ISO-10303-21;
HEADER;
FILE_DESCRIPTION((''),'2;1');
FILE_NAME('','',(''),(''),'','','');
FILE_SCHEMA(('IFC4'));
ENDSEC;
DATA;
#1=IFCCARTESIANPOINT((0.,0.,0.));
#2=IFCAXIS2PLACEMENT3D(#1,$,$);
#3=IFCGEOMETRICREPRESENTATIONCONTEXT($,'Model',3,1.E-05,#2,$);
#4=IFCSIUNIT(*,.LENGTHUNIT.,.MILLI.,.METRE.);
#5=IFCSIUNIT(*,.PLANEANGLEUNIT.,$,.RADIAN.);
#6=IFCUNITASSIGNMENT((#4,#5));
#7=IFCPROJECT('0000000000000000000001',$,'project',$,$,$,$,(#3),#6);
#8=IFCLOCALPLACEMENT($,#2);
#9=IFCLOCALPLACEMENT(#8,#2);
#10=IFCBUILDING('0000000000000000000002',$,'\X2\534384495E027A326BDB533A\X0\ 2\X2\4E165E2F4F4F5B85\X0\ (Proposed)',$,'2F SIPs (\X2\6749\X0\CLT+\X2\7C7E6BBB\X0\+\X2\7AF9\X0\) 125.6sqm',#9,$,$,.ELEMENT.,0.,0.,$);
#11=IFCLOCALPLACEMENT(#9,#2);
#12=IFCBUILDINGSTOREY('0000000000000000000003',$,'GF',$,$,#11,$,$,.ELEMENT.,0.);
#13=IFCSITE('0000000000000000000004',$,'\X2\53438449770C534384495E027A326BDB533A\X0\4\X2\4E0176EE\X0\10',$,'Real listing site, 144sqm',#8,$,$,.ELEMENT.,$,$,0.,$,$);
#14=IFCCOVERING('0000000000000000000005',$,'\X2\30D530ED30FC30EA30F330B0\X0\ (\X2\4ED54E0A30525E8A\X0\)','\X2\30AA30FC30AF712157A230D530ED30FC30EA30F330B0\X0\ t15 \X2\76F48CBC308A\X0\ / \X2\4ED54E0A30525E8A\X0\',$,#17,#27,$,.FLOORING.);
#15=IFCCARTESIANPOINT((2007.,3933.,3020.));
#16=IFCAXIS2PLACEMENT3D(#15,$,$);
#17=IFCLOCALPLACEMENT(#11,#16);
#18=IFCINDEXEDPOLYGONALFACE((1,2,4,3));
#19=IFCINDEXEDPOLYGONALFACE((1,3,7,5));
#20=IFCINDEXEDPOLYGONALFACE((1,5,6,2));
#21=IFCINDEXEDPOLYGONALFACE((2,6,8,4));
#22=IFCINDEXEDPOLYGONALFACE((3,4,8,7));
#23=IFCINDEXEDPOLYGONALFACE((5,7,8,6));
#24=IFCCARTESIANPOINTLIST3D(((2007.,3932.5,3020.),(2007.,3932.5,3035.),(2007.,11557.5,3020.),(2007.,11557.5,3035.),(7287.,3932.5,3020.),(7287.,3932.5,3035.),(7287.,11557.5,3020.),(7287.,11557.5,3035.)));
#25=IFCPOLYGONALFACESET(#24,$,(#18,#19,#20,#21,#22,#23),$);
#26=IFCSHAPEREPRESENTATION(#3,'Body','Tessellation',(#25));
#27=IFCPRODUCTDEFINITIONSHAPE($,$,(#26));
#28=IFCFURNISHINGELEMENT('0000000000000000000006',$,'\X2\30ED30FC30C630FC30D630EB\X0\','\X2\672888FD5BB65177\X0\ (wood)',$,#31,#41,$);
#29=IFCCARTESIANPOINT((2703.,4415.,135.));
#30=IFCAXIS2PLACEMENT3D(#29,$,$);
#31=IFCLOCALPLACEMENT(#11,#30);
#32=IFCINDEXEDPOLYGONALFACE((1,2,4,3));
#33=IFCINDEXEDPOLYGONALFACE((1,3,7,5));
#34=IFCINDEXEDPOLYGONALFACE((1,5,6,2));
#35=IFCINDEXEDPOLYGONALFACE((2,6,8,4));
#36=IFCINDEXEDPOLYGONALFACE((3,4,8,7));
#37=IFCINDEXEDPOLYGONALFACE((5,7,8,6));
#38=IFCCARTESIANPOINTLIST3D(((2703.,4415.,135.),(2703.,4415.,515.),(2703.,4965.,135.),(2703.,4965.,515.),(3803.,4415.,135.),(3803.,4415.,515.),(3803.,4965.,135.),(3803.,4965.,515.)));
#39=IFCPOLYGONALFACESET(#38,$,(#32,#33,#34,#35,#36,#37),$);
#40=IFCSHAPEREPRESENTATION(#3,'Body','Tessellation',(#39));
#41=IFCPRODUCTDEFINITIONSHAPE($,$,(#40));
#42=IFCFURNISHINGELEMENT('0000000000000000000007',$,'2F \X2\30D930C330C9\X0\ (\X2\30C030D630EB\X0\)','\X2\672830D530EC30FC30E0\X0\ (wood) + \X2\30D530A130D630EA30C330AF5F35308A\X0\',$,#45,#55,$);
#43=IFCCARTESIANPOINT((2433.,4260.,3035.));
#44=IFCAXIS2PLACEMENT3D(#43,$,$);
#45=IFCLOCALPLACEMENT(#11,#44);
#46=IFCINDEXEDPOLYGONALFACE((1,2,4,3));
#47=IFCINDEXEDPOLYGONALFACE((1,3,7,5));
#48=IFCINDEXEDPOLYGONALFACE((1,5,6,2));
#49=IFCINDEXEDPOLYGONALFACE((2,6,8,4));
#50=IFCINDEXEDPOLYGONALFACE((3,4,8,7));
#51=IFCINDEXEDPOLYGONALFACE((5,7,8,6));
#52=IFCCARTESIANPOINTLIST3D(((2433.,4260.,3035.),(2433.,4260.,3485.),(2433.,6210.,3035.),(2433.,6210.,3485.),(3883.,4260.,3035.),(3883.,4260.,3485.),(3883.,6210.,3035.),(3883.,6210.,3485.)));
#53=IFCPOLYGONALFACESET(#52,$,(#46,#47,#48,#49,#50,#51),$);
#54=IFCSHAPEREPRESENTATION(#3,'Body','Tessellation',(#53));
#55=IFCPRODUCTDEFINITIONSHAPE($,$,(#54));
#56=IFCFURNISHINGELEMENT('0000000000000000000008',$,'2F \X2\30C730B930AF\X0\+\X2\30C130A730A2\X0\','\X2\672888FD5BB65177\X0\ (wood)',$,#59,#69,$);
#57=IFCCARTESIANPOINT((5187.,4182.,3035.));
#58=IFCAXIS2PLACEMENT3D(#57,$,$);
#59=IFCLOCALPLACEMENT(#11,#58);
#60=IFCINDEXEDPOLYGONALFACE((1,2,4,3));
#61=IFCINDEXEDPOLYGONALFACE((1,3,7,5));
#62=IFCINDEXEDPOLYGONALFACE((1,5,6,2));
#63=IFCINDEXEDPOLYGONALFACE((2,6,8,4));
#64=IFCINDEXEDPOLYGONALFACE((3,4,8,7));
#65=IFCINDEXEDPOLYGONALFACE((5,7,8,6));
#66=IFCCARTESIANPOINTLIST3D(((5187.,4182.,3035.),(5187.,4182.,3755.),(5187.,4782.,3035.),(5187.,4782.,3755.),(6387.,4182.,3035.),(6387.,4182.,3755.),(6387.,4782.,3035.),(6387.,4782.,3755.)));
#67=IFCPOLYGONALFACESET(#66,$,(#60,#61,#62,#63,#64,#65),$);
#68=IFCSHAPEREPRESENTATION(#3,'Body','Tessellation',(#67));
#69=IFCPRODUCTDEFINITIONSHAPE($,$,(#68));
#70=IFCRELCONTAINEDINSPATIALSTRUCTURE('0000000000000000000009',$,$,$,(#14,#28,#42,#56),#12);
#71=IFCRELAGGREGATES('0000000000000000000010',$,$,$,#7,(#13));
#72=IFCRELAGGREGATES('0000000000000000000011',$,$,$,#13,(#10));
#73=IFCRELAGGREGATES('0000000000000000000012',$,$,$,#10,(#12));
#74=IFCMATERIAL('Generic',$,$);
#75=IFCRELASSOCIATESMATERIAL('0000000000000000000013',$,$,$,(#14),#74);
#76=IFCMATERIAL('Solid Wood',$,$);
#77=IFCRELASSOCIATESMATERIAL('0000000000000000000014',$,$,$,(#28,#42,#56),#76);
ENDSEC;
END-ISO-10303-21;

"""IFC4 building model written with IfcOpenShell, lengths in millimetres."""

from ifc_helpers import new_model, si_unit, frame, frame_2d, origin, place, context, project, spatial, rectangle, extrude, material, element, save


model = new_model("IFC4")

# Units and contexts
model_context = context("Model", 3, precision=1e-05, world=origin())
ifc_project = project(units=[si_unit("LENGTHUNIT", "METRE", prefix="MILLI"), si_unit("PLANEANGLEUNIT", "RADIAN")], contexts=[model_context])

# Site, building, storey
site_placement = place(None, origin())
site = spatial("IfcSite", under=ifc_project, at=site_placement, Name="千葉県千葉市稲毛区4丁目10", ObjectType="Real listing site, 144sqm", CompositionType="ELEMENT", RefElevation=0.0)
building_placement = place(site_placement, origin())
building = spatial("IfcBuilding", under=site, at=building_placement, Name="千葉市稲毛区 2世帯住宅 (Proposed)", ObjectType="2F SIPs (杉CLT+籾殻+竹) 125.6sqm", CompositionType="ELEMENT", ElevationOfRefHeight=0.0, ElevationOfTerrain=0.0)
storey_placement = place(building_placement, origin())
storey = spatial("IfcBuildingStorey", under=building, at=storey_placement, Name="GF", CompositionType="ELEMENT", Elevation=0.0)

# Shared definitions
ifc_material_1 = material(Name="Solid Wood")

# Shared definitions
ifc_material_2 = material(Name="Generic")

# Covering
covering_placement = place(storey_placement, frame((2007.0, 3933.0, 3020.0)))
element("IfcCovering", 1, at=covering_placement, inside=storey, material=ifc_material_2, Name="フローリング (仕上げ床)", Description="オーク無垢フローリング t15 直貼り / 仕上げ床", PredefinedType="FLOORING", context=model_context, shape_type="SweptSolid", body=[
    extrude(rectangle(XDim=5280.0, YDim=7625.0, at=frame_2d((2640.0, 3812.0))), frame((2007.0, 3933.0, 3020.0)), (0.0, 0.0, 1.0), 15.0),
])

# Furnishing elements
furnishing_1_placement = place(storey_placement, frame((2703.0, 4415.0, 135.0)))
element("IfcFurnishingElement", 2, at=furnishing_1_placement, inside=storey, material=ifc_material_1, Name="ローテーブル", Description="木製家具 (wood)", context=model_context, shape_type="SweptSolid", body=[
    extrude(rectangle(XDim=1100.0, YDim=550.0, at=frame_2d((550.0, 275.0))), frame((2703.0, 4415.0, 135.0)), (0.0, 0.0, 1.0), 380.0),
])
furnishing_2_placement = place(storey_placement, frame((2433.0, 4260.0, 3035.0)))
element("IfcFurnishingElement", 3, at=furnishing_2_placement, inside=storey, material=ifc_material_1, Name="2F ベッド (ダブル)", Description="木フレーム (wood) + ファブリック張り", context=model_context, shape_type="SweptSolid", body=[
    extrude(rectangle(XDim=1450.0, YDim=1950.0, at=frame_2d((725.0, 975.0))), frame((2433.0, 4260.0, 3035.0)), (0.0, 0.0, 1.0), 450.0),
])
furnishing_3_placement = place(storey_placement, frame((5187.0, 4182.0, 3035.0)))
element("IfcFurnishingElement", 4, at=furnishing_3_placement, inside=storey, material=ifc_material_1, Name="2F デスク+チェア", Description="木製家具 (wood)", context=model_context, shape_type="SweptSolid", body=[
    extrude(rectangle(XDim=1200.0, YDim=600.0, at=frame_2d((600.0, 300.0))), frame((5187.0, 4182.0, 3035.0)), (0.0, 0.0, 1.0), 720.0),
])

save(model, "model.ifc")
